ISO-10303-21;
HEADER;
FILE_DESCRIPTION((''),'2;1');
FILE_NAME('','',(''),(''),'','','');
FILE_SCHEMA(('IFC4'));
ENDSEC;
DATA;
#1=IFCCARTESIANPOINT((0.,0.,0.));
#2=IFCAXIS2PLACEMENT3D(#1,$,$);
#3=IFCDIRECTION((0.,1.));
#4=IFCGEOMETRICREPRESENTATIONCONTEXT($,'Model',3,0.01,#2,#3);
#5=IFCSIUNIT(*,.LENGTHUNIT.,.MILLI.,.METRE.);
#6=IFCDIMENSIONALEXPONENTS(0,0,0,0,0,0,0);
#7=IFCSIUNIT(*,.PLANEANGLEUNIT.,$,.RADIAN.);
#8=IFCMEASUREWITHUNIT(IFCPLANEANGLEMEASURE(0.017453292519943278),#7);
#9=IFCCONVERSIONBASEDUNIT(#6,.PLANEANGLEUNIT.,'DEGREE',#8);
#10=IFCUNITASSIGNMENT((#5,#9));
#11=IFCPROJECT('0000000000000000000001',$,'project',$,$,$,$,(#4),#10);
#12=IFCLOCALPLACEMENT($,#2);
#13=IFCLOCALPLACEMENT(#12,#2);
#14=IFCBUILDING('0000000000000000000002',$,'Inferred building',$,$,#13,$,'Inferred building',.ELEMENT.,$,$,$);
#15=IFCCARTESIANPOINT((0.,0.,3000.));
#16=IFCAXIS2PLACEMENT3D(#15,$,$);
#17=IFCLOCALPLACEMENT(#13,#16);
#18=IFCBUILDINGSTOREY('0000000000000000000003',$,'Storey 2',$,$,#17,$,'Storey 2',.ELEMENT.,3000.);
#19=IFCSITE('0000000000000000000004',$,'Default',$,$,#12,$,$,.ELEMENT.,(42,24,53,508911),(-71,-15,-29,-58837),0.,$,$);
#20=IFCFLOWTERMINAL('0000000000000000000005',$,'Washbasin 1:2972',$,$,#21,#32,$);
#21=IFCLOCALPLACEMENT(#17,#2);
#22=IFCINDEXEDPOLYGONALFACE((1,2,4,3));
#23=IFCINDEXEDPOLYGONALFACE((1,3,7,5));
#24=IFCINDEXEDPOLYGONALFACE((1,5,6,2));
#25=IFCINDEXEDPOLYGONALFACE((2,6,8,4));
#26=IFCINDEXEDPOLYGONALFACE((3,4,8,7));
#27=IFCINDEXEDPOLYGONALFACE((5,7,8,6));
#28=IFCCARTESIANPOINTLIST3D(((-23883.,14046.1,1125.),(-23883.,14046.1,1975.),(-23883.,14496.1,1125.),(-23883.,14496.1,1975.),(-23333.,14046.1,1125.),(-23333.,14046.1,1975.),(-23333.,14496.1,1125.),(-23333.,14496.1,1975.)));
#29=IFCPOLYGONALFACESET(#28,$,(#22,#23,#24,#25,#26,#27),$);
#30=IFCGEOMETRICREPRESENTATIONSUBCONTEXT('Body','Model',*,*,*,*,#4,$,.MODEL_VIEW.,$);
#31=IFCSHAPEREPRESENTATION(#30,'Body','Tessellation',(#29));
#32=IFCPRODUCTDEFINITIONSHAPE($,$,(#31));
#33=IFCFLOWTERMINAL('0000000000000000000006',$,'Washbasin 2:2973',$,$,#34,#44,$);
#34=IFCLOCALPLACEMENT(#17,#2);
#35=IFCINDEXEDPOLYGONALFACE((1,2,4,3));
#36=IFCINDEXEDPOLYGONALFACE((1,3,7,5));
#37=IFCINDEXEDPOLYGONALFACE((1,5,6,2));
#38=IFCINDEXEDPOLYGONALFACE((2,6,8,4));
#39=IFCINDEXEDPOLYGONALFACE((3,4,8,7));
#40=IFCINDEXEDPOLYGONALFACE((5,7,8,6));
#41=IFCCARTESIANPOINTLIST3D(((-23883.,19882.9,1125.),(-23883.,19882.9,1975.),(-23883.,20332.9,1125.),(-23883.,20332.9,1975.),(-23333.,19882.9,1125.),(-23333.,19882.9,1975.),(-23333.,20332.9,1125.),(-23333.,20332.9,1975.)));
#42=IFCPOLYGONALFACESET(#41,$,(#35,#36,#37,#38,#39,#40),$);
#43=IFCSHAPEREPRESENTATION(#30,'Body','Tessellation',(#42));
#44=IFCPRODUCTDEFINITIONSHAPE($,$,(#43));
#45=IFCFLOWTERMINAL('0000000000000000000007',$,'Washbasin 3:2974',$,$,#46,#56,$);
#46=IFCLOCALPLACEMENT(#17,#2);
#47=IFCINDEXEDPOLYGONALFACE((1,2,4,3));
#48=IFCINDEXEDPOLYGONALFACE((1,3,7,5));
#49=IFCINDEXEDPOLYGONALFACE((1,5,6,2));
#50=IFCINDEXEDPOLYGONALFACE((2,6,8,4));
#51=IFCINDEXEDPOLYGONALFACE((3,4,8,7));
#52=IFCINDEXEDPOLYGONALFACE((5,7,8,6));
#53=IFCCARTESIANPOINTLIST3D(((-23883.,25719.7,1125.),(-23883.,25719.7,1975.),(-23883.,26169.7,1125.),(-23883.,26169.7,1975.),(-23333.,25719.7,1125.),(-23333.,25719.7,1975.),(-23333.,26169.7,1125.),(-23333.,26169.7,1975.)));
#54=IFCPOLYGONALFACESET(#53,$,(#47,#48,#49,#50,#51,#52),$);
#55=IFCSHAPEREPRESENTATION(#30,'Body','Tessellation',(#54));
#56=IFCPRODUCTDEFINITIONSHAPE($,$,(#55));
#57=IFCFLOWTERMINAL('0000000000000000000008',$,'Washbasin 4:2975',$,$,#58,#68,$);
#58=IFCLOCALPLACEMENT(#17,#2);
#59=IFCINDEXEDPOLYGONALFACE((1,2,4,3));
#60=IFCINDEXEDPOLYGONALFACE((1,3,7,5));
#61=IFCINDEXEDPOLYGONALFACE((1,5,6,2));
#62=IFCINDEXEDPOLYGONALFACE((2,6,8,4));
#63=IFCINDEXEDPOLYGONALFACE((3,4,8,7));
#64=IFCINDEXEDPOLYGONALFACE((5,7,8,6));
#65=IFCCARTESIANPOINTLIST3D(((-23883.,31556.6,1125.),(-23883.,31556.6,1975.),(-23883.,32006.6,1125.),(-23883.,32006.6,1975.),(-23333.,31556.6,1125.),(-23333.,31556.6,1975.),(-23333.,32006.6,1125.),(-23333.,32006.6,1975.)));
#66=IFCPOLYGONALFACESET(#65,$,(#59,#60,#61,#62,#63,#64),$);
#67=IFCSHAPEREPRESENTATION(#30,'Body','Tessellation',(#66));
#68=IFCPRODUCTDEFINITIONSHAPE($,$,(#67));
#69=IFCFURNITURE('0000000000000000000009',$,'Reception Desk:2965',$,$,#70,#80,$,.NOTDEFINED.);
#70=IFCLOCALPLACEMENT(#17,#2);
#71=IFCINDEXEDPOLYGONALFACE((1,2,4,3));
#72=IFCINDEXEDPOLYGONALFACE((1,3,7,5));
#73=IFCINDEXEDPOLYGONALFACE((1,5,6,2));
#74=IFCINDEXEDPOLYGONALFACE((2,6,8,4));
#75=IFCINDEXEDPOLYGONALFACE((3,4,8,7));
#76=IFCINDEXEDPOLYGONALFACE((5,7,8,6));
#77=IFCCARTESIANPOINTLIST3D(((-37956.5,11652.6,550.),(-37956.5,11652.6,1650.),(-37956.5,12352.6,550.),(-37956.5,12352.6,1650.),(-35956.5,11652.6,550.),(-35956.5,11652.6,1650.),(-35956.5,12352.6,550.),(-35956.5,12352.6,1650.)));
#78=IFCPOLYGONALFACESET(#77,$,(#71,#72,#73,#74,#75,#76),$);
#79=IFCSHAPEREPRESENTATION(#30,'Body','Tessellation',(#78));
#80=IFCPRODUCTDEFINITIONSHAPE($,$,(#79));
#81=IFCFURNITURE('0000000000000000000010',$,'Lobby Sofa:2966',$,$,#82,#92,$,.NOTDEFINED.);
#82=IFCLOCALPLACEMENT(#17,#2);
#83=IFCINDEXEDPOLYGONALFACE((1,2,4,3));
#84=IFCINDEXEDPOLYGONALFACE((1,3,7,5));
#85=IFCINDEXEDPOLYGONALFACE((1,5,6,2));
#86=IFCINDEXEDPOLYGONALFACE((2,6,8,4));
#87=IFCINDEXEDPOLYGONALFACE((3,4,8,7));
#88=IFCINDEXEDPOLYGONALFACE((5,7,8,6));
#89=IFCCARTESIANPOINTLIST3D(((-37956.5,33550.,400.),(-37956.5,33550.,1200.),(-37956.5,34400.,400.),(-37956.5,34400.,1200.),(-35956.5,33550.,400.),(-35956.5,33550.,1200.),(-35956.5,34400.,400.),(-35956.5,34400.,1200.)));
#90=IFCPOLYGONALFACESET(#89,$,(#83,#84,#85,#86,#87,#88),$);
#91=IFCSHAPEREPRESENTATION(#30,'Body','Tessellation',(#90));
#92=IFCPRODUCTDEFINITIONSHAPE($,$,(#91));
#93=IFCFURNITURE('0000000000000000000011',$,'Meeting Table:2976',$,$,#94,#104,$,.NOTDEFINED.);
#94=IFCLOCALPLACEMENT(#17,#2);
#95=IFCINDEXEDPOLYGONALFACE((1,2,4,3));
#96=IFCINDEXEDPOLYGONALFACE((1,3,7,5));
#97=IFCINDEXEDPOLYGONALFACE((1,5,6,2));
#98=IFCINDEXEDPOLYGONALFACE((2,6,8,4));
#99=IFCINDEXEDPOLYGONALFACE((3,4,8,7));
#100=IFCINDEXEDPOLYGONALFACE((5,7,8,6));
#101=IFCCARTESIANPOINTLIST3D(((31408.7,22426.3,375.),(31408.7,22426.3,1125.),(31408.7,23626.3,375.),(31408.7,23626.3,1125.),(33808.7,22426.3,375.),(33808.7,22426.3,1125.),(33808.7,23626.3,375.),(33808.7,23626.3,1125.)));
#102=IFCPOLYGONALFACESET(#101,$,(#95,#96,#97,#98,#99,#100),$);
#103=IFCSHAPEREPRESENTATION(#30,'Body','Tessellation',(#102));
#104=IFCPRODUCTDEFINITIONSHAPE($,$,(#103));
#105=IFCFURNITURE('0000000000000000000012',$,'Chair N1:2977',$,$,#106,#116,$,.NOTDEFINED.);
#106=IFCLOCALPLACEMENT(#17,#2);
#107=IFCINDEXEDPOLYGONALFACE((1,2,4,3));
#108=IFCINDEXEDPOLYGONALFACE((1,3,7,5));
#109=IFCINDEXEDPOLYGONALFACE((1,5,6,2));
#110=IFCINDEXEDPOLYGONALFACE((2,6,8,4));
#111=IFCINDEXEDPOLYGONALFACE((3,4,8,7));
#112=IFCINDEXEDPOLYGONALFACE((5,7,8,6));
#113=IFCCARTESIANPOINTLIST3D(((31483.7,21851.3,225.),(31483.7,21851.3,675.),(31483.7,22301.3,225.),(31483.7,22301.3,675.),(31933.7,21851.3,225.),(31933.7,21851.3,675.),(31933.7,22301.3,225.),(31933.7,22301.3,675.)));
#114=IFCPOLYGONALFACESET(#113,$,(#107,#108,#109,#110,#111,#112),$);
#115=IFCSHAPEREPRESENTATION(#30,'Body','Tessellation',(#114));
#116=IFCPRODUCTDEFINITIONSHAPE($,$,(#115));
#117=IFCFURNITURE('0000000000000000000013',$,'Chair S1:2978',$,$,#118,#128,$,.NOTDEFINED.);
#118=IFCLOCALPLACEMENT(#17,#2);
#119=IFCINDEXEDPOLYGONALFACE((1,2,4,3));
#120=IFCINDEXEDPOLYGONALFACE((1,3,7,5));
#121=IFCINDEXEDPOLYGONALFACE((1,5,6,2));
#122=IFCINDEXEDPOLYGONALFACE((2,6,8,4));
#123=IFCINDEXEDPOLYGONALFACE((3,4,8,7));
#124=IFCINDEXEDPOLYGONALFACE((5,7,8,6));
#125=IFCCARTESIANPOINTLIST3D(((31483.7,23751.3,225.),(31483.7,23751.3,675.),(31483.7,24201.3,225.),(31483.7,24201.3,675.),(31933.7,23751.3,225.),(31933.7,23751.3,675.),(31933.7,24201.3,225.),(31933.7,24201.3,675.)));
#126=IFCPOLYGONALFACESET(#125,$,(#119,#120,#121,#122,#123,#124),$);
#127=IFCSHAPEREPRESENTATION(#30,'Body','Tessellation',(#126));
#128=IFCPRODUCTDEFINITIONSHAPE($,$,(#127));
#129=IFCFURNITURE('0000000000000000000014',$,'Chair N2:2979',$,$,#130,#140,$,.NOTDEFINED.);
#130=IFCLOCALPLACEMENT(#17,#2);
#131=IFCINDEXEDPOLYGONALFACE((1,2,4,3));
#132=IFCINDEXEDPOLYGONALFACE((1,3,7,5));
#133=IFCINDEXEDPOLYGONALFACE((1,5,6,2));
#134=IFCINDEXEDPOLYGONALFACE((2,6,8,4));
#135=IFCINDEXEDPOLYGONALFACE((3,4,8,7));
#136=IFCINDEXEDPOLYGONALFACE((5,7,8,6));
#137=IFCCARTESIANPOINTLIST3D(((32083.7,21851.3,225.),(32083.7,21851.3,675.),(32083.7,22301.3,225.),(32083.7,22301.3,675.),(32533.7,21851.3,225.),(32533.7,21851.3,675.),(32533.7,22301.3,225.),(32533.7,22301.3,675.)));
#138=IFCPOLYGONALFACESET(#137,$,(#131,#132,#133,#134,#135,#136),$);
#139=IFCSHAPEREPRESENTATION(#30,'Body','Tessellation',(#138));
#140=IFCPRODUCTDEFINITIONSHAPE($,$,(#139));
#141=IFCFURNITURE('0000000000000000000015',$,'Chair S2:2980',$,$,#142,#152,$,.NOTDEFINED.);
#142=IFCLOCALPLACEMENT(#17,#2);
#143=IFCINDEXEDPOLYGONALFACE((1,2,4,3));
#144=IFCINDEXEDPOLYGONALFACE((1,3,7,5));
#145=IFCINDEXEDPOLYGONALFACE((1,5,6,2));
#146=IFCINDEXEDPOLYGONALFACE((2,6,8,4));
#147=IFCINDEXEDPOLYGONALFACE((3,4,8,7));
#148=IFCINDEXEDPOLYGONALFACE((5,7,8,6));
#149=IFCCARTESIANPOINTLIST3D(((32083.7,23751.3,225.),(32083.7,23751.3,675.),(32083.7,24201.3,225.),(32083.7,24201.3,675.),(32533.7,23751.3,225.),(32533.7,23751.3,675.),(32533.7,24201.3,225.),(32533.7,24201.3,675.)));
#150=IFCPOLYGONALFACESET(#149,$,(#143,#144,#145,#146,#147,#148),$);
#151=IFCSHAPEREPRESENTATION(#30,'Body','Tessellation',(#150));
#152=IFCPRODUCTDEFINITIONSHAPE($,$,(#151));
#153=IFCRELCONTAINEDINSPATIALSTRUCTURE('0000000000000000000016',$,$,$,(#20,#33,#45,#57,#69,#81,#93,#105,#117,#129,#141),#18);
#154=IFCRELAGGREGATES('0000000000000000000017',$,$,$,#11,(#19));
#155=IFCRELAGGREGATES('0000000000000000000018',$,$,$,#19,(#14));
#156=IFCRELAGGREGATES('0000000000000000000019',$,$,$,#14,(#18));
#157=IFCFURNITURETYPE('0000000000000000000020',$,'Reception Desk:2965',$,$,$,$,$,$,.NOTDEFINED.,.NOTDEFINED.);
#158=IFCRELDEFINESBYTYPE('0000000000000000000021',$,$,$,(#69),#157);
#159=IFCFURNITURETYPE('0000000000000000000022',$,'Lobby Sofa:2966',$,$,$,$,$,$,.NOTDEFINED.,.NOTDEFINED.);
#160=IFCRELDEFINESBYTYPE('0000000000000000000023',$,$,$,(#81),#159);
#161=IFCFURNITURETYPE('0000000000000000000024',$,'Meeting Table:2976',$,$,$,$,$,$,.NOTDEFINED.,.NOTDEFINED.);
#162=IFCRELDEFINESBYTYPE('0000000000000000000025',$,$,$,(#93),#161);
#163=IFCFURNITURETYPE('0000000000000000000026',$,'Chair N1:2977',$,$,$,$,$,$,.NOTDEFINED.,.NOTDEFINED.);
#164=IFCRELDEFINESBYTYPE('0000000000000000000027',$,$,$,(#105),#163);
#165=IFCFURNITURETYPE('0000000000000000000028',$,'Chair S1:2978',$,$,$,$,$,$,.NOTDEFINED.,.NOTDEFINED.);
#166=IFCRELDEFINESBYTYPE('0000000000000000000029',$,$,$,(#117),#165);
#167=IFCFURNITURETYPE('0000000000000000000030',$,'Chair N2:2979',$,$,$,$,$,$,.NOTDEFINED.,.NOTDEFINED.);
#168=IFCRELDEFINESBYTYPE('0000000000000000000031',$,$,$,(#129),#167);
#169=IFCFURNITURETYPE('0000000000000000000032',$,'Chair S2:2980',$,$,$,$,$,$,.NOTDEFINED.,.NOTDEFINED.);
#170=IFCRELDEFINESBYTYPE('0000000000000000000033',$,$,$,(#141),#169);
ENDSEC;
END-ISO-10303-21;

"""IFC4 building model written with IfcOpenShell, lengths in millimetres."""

from ifc_helpers import new_model, entity, si_unit, converted_unit, direction, frame, origin, origin_2d_with_axis, place, context, subcontext, project, spatial, rectangle, extrude, type_object, element, save


model = new_model("IFC4")

# Units and contexts
model_context = context("Model", 3, precision=0.01, world=origin(), true_north=direction((0.0, 1.0)))
body_context = subcontext(model_context, "Body", "Model", "MODEL_VIEW")
ifc_project = project(units=[si_unit("LENGTHUNIT", "METRE", prefix="MILLI"), converted_unit("PLANEANGLEUNIT", "DEGREE", entity("IfcPlaneAngleMeasure", 0.017453292519943278), si_unit("PLANEANGLEUNIT", "RADIAN"), dimensions=[0, 0, 0, 0, 0, 0, 0])], contexts=[model_context])

# Site, building, storey
site_placement = place(None, origin())
site = spatial("IfcSite", under=ifc_project, at=site_placement, Name="Default", CompositionType="ELEMENT", RefLatitude=(42, 24, 53, 508911), RefLongitude=(-71, -15, -29, -58837), RefElevation=0.0)
building_placement = place(site_placement, origin())
building = spatial("IfcBuilding", under=site, at=building_placement, Name="Inferred building", LongName="Inferred building", CompositionType="ELEMENT")
storey_placement = place(building_placement, frame((0.0, 0.0, 3000.0)))
storey = spatial("IfcBuildingStorey", under=building, at=storey_placement, Name="Storey 2", LongName="Storey 2", CompositionType="ELEMENT", Elevation=3000.0)

# Flow terminals
flow_terminal_1_placement = place(storey_placement, origin())
element("IfcFlowTerminal", 1, at=flow_terminal_1_placement, inside=storey, Name="Washbasin 1:2972", context=body_context, shape_type="SweptSolid", body=[
    extrude(rectangle(XDim=450.0, YDim=550.0, at=origin_2d_with_axis()), frame((-23608.0, 14271.1, 1125.0), z_axis=(0.0, 0.0, 1.0), x_axis=(0.0, 1.0, 0.0)), (0.0, 0.0, 1.0), 850.0),
])
flow_terminal_2_placement = place(storey_placement, origin())
element("IfcFlowTerminal", 2, at=flow_terminal_2_placement, inside=storey, Name="Washbasin 2:2973", context=body_context, shape_type="SweptSolid", body=[
    extrude(rectangle(XDim=450.0, YDim=550.0, at=origin_2d_with_axis()), frame((-23608.0, 20107.9, 1125.0), z_axis=(0.0, 0.0, 1.0), x_axis=(0.0, 1.0, 0.0)), (0.0, 0.0, 1.0), 850.0),
])
flow_terminal_3_placement = place(storey_placement, origin())
element("IfcFlowTerminal", 3, at=flow_terminal_3_placement, inside=storey, Name="Washbasin 3:2974", context=body_context, shape_type="SweptSolid", body=[
    extrude(rectangle(XDim=450.0, YDim=550.0, at=origin_2d_with_axis()), frame((-23608.0, 25944.7, 1125.0), z_axis=(0.0, 0.0, 1.0), x_axis=(0.0, 1.0, 0.0)), (0.0, 0.0, 1.0), 850.0),
])
flow_terminal_4_placement = place(storey_placement, origin())
element("IfcFlowTerminal", 4, at=flow_terminal_4_placement, inside=storey, Name="Washbasin 4:2975", context=body_context, shape_type="SweptSolid", body=[
    extrude(rectangle(XDim=450.0, YDim=550.0, at=origin_2d_with_axis()), frame((-23608.0, 31781.6, 1125.0), z_axis=(0.0, 0.0, 1.0), x_axis=(0.0, 1.0, 0.0)), (0.0, 0.0, 1.0), 850.0),
])

# Furniture
furniture_type_1 = type_object("IfcFurnitureType", Name="Reception Desk:2965", PredefinedType="NOTDEFINED")
furniture_1_placement = place(storey_placement, origin())
element("IfcFurniture", 5, at=furniture_1_placement, inside=storey, type_object=furniture_type_1, Name="Reception Desk:2965", PredefinedType="NOTDEFINED", context=body_context, shape_type="SweptSolid", body=[
    extrude(rectangle(XDim=2000.0, YDim=700.0, at=origin_2d_with_axis()), frame((-36956.5, 12002.6, 550.0)), (0.0, 0.0, 1.0), 1100.0),
])
furniture_type_2 = type_object("IfcFurnitureType", Name="Lobby Sofa:2966", PredefinedType="NOTDEFINED")
furniture_2_placement = place(storey_placement, origin())
element("IfcFurniture", 6, at=furniture_2_placement, inside=storey, type_object=furniture_type_2, Name="Lobby Sofa:2966", PredefinedType="NOTDEFINED", context=body_context, shape_type="SweptSolid", body=[
    extrude(rectangle(XDim=2000.0, YDim=850.0, at=origin_2d_with_axis()), frame((-36956.5, 33975.0, 400.0)), (0.0, 0.0, 1.0), 800.0),
])
furniture_type_3 = type_object("IfcFurnitureType", Name="Meeting Table:2976", PredefinedType="NOTDEFINED")
furniture_3_placement = place(storey_placement, origin())
element("IfcFurniture", 7, at=furniture_3_placement, inside=storey, type_object=furniture_type_3, Name="Meeting Table:2976", PredefinedType="NOTDEFINED", context=body_context, shape_type="SweptSolid", body=[
    extrude(rectangle(XDim=2400.0, YDim=1200.0, at=origin_2d_with_axis()), frame((32608.7, 23026.3, 375.0)), (0.0, 0.0, 1.0), 750.0),
])
furniture_type_4 = type_object("IfcFurnitureType", Name="Chair N1:2977", PredefinedType="NOTDEFINED")
furniture_4_placement = place(storey_placement, origin())
element("IfcFurniture", 8, at=furniture_4_placement, inside=storey, type_object=furniture_type_4, Name="Chair N1:2977", PredefinedType="NOTDEFINED", context=body_context, shape_type="SweptSolid", body=[
    extrude(rectangle(XDim=450.0, YDim=450.0, at=origin_2d_with_axis()), frame((31708.7, 22076.3, 225.0)), (0.0, 0.0, 1.0), 450.0),
])
furniture_type_5 = type_object("IfcFurnitureType", Name="Chair S1:2978", PredefinedType="NOTDEFINED")
furniture_5_placement = place(storey_placement, origin())
element("IfcFurniture", 9, at=furniture_5_placement, inside=storey, type_object=furniture_type_5, Name="Chair S1:2978", PredefinedType="NOTDEFINED", context=body_context, shape_type="SweptSolid", body=[
    extrude(rectangle(XDim=450.0, YDim=450.0, at=origin_2d_with_axis()), frame((31708.7, 23976.3, 225.0)), (0.0, 0.0, 1.0), 450.0),
])
furniture_type_6 = type_object("IfcFurnitureType", Name="Chair N2:2979", PredefinedType="NOTDEFINED")
furniture_6_placement = place(storey_placement, origin())
element("IfcFurniture", 10, at=furniture_6_placement, inside=storey, type_object=furniture_type_6, Name="Chair N2:2979", PredefinedType="NOTDEFINED", context=body_context, shape_type="SweptSolid", body=[
    extrude(rectangle(XDim=450.0, YDim=450.0, at=origin_2d_with_axis()), frame((32308.7, 22076.3, 225.0)), (0.0, 0.0, 1.0), 450.0),
])
furniture_type_7 = type_object("IfcFurnitureType", Name="Chair S2:2980", PredefinedType="NOTDEFINED")
furniture_7_placement = place(storey_placement, origin())
element("IfcFurniture", 11, at=furniture_7_placement, inside=storey, type_object=furniture_type_7, Name="Chair S2:2980", PredefinedType="NOTDEFINED", context=body_context, shape_type="SweptSolid", body=[
    extrude(rectangle(XDim=450.0, YDim=450.0, at=origin_2d_with_axis()), frame((32308.7, 23976.3, 225.0)), (0.0, 0.0, 1.0), 450.0),
])

save(model, "model.ifc")
